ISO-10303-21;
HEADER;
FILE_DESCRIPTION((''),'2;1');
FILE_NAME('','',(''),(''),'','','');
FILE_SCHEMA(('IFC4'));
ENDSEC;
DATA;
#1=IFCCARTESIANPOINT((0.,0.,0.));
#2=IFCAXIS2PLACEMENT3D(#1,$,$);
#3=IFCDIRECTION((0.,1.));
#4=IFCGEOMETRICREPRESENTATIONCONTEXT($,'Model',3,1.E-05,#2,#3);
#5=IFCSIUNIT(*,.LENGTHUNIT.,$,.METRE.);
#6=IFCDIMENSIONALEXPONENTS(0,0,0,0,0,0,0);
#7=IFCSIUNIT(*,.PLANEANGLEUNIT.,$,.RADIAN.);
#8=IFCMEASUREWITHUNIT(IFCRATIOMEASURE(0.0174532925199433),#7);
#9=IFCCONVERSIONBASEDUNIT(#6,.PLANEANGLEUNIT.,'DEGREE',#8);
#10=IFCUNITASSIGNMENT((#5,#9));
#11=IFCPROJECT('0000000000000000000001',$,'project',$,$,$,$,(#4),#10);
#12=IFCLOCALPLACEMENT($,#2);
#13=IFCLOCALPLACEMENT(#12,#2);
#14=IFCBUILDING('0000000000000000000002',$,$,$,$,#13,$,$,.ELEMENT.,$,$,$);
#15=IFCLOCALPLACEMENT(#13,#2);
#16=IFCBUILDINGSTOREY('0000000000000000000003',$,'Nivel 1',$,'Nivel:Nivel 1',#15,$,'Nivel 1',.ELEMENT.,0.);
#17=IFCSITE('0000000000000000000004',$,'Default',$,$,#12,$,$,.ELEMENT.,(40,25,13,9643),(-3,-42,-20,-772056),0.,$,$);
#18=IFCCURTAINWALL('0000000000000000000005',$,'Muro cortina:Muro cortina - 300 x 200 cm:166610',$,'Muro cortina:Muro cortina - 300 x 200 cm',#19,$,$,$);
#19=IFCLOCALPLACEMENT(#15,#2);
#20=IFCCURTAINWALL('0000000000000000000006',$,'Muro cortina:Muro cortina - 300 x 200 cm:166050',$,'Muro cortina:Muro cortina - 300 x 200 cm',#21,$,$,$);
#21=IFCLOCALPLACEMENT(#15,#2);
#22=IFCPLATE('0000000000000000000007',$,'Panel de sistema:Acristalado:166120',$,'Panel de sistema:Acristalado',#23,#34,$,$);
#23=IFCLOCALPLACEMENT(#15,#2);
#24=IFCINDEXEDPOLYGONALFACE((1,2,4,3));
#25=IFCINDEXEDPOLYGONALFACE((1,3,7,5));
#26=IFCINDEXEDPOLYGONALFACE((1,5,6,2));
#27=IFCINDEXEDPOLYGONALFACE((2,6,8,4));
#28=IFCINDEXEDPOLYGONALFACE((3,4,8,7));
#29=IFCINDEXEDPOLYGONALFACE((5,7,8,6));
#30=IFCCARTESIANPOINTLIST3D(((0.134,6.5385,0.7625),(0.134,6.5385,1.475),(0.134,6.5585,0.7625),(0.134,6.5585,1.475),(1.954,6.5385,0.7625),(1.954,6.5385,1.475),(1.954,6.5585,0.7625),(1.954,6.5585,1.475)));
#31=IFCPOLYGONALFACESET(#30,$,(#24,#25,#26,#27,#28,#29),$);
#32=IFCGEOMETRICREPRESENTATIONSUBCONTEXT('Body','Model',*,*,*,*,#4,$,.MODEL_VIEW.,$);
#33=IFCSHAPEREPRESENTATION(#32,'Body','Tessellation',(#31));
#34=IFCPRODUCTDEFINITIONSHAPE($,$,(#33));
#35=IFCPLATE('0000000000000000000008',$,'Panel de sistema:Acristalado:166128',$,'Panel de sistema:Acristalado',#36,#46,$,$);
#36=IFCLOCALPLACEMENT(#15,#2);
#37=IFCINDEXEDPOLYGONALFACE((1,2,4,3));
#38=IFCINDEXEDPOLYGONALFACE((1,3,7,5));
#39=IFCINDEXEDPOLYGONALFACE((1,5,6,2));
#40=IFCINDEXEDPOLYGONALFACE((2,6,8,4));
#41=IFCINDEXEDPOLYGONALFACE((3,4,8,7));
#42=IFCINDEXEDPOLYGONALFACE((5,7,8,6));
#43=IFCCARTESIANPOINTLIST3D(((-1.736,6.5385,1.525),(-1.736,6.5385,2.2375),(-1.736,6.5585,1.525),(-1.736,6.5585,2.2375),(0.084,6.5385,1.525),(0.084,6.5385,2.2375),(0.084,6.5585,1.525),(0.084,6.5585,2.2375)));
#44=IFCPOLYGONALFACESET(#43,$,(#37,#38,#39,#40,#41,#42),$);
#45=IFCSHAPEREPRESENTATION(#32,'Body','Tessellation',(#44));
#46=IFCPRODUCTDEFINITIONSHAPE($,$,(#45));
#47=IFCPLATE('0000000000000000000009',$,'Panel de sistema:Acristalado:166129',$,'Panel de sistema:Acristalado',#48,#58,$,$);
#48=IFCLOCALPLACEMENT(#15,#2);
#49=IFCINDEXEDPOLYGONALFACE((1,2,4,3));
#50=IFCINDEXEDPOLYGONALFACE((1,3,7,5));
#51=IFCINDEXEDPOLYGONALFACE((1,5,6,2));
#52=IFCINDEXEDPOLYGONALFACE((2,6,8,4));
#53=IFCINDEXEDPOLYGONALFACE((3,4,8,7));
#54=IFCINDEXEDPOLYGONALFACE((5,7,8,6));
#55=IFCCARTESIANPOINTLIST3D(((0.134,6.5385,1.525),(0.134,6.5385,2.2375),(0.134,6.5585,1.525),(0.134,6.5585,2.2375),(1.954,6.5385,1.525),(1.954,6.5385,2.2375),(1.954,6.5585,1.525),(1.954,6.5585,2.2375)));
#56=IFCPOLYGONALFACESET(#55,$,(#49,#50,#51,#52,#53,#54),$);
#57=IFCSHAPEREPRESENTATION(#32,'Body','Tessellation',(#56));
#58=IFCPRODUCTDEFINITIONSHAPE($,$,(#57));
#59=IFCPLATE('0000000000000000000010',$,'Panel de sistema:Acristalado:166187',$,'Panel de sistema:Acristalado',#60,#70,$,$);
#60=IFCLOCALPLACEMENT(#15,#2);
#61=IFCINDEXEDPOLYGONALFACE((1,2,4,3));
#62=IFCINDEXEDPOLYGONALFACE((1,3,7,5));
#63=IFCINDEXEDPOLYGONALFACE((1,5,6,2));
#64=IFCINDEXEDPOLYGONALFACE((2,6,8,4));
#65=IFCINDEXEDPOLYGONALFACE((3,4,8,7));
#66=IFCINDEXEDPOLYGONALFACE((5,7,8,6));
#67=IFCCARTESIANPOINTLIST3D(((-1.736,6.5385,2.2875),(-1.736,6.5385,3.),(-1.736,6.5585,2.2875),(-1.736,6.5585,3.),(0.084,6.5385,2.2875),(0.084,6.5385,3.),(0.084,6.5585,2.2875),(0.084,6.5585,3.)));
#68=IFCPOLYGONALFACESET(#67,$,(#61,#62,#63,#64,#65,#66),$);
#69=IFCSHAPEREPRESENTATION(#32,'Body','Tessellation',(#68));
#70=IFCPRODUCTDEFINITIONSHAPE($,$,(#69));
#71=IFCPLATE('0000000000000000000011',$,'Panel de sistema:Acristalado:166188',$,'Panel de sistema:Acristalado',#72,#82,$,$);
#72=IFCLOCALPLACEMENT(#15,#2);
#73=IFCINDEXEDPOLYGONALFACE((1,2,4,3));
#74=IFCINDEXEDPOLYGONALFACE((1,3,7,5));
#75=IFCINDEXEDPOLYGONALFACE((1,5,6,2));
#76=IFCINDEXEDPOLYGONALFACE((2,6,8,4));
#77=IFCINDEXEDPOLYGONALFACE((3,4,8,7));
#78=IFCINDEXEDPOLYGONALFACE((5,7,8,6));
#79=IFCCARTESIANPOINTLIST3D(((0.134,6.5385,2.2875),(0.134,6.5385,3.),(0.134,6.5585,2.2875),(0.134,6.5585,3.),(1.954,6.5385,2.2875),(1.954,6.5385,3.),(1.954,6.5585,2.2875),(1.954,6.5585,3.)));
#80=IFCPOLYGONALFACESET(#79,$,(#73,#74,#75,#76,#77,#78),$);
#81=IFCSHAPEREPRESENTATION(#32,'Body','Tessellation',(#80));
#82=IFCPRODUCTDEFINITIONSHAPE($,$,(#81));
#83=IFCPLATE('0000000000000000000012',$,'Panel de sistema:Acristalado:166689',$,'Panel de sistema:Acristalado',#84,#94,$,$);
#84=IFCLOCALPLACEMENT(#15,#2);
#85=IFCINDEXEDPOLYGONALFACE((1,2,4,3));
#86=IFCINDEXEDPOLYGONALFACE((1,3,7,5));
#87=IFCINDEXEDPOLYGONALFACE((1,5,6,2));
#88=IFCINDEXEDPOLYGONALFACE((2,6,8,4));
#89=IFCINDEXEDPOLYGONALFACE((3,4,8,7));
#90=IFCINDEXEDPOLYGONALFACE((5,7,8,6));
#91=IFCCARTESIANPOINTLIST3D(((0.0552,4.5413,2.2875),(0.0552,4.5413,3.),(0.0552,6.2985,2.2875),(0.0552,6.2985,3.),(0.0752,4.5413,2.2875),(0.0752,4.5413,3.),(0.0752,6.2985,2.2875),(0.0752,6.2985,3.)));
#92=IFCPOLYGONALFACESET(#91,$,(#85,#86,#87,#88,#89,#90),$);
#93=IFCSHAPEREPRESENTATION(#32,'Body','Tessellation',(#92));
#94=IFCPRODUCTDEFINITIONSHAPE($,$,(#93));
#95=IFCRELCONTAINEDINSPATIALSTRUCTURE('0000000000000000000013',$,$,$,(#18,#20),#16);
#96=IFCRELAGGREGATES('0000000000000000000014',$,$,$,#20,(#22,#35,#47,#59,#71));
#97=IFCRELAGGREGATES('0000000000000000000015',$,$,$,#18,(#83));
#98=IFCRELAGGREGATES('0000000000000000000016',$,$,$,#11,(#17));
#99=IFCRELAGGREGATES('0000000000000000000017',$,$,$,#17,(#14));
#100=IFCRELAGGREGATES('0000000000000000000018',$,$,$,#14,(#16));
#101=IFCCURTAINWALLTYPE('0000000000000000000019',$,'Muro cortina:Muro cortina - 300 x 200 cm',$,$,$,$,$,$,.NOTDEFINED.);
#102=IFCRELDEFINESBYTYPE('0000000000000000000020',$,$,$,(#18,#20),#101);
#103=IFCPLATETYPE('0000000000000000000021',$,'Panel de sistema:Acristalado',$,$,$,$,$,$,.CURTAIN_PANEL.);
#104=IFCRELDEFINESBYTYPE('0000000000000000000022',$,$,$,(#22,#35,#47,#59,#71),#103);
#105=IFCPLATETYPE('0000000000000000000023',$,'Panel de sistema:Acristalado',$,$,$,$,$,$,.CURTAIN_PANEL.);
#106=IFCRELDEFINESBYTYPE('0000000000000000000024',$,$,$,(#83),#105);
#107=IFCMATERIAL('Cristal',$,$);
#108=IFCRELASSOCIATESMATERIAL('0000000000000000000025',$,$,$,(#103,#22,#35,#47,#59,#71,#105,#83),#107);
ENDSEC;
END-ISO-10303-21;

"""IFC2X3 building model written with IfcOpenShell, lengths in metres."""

from ifc_helpers import new_model, entity, si_unit, converted_unit, direction, frame, origin, origin_2d_with_axis, place, context, subcontext, project, spatial, rectangle, extrude, source, transform, mapped, material, type_object, type_shapes, element, aggregate, save


model = new_model("IFC2X3")

# Units and contexts
model_context = context("Model", 3, precision=1e-05, world=origin(), true_north=direction((0.0, 1.0)))
body_context = subcontext(model_context, "Body", "Model", "MODEL_VIEW")
ifc_project = project(units=[si_unit("LENGTHUNIT", "METRE"), converted_unit("PLANEANGLEUNIT", "DEGREE", entity("IfcRatioMeasure", 0.0174532925199433), si_unit("PLANEANGLEUNIT", "RADIAN"), dimensions=[0, 0, 0, 0, 0, 0, 0])], contexts=[model_context])

# Site, building, storey
site_placement = place(None, origin())
site = spatial("IfcSite", under=ifc_project, at=site_placement, Name="Default", CompositionType="ELEMENT", RefLatitude=(40, 25, 13, 9643), RefLongitude=(-3, -42, -20, -772056), RefElevation=0.0)
building_placement = place(site_placement, origin())
building = spatial("IfcBuilding", under=site, at=building_placement, CompositionType="ELEMENT")
storey_placement = place(building_placement, origin())
storey = spatial("IfcBuildingStorey", under=building, at=storey_placement, Name="Nivel 1", ObjectType="Nivel:Nivel 1", LongName="Nivel 1", CompositionType="ELEMENT", Elevation=0.0)

# Curtain wall
curtain_wall_type = type_object("IfcCurtainWallType", Name="Muro cortina:Muro cortina - 300 x 200 cm", PredefinedType="NOTDEFINED")
curtain_wall_1_placement = place(storey_placement, origin())
curtain_wall_1 = element("IfcCurtainWall", 1, at=curtain_wall_1_placement, inside=storey, type_object=curtain_wall_type, Name="Muro cortina:Muro cortina - 300 x 200 cm:166610", ObjectType="Muro cortina:Muro cortina - 300 x 200 cm")

# Curtain wall, plates
curtain_wall_2_placement = place(storey_placement, origin())
curtain_wall_2 = element("IfcCurtainWall", 2, at=curtain_wall_2_placement, inside=storey, type_object=curtain_wall_type, Name="Muro cortina:Muro cortina - 300 x 200 cm:166050", ObjectType="Muro cortina:Muro cortina - 300 x 200 cm")
ifc_material_1 = material(Name="Cristal")
plate_type_1 = type_object("IfcPlateType", Name="Panel de sistema:Acristalado", PredefinedType="CURTAIN_PANEL", material=ifc_material_1)
shared_shape_1 = source(origin(), body_context, "Body", "SweptSolid", [
    extrude(rectangle(XDim=0.02, YDim=1.82, at=origin_2d_with_axis()), frame((0.0, 0.0, 0.0), z_axis=(0.0, 0.0, 1.0), x_axis=(0.0, 1.0, 0.0)), (0.0, 0.0, 1.0), 0.7125),
])
type_shapes(plate_type_1, [shared_shape_1])
plate_1_placement = place(curtain_wall_2_placement, frame((1.044, 6.5485, 0.7625)))
plate_1 = element("IfcPlate", 3, at=plate_1_placement, type_object=plate_type_1, material=ifc_material_1, Name="Panel de sistema:Acristalado:166120", ObjectType="Panel de sistema:Acristalado", context=body_context, shape_type="MappedRepresentation", body=[
    mapped(shared_shape_1, transform((0.0, 0.0, 0.0), scale=1.0)),
])
plate_2_placement = place(curtain_wall_2_placement, frame((-0.826, 6.5485, 1.525)))
plate_2 = element("IfcPlate", 4, at=plate_2_placement, type_object=plate_type_1, material=ifc_material_1, Name="Panel de sistema:Acristalado:166128", ObjectType="Panel de sistema:Acristalado", context=body_context, shape_type="MappedRepresentation", body=[
    mapped(shared_shape_1, transform((0.0, 0.0, 0.0), scale=1.0)),
])
plate_3_placement = place(curtain_wall_2_placement, frame((1.044, 6.5485, 1.525)))
plate_3 = element("IfcPlate", 5, at=plate_3_placement, type_object=plate_type_1, material=ifc_material_1, Name="Panel de sistema:Acristalado:166129", ObjectType="Panel de sistema:Acristalado", context=body_context, shape_type="MappedRepresentation", body=[
    mapped(shared_shape_1, transform((0.0, 0.0, 0.0), scale=1.0)),
])
plate_4_placement = place(curtain_wall_2_placement, frame((-0.826, 6.5485, 2.2875)))
plate_4 = element("IfcPlate", 6, at=plate_4_placement, type_object=plate_type_1, material=ifc_material_1, Name="Panel de sistema:Acristalado:166187", ObjectType="Panel de sistema:Acristalado", context=body_context, shape_type="MappedRepresentation", body=[
    mapped(shared_shape_1, transform((0.0, 0.0, 0.0), scale=1.0)),
])
plate_5_placement = place(curtain_wall_2_placement, frame((1.044, 6.5485, 2.2875)))
plate_5 = element("IfcPlate", 7, at=plate_5_placement, type_object=plate_type_1, material=ifc_material_1, Name="Panel de sistema:Acristalado:166188", ObjectType="Panel de sistema:Acristalado", context=body_context, shape_type="MappedRepresentation", body=[
    mapped(shared_shape_1, transform((0.0, 0.0, 0.0), scale=1.0)),
])
aggregate(curtain_wall_2, [plate_1, plate_2, plate_3, plate_4, plate_5])

# Plate
plate_type_2 = type_object("IfcPlateType", Name="Panel de sistema:Acristalado", PredefinedType="CURTAIN_PANEL", material=ifc_material_1)
shared_shape_2 = source(origin(), body_context, "Body", "SweptSolid", [
    extrude(rectangle(XDim=0.02, YDim=1.7571, at=origin_2d_with_axis()), frame((0.0, 0.0, 0.0), z_axis=(0.0, 0.0, 1.0), x_axis=(0.0, 1.0, 0.0)), (0.0, 0.0, 1.0), 0.7125),
])
type_shapes(plate_type_2, [shared_shape_2])
plate_6_placement = place(curtain_wall_1_placement, frame((0.0652, 5.4199, 2.2875), z_axis=(0.0, 0.0, 1.0), x_axis=(0.0, -1.0, 0.0)))
plate_6 = element("IfcPlate", 8, at=plate_6_placement, type_object=plate_type_2, material=ifc_material_1, Name="Panel de sistema:Acristalado:166689", ObjectType="Panel de sistema:Acristalado", context=body_context, shape_type="MappedRepresentation", body=[
    mapped(shared_shape_2, transform((0.0, 0.0, 0.0), scale=1.0)),
])
aggregate(curtain_wall_1, [plate_6])

save(model, "model.ifc")
